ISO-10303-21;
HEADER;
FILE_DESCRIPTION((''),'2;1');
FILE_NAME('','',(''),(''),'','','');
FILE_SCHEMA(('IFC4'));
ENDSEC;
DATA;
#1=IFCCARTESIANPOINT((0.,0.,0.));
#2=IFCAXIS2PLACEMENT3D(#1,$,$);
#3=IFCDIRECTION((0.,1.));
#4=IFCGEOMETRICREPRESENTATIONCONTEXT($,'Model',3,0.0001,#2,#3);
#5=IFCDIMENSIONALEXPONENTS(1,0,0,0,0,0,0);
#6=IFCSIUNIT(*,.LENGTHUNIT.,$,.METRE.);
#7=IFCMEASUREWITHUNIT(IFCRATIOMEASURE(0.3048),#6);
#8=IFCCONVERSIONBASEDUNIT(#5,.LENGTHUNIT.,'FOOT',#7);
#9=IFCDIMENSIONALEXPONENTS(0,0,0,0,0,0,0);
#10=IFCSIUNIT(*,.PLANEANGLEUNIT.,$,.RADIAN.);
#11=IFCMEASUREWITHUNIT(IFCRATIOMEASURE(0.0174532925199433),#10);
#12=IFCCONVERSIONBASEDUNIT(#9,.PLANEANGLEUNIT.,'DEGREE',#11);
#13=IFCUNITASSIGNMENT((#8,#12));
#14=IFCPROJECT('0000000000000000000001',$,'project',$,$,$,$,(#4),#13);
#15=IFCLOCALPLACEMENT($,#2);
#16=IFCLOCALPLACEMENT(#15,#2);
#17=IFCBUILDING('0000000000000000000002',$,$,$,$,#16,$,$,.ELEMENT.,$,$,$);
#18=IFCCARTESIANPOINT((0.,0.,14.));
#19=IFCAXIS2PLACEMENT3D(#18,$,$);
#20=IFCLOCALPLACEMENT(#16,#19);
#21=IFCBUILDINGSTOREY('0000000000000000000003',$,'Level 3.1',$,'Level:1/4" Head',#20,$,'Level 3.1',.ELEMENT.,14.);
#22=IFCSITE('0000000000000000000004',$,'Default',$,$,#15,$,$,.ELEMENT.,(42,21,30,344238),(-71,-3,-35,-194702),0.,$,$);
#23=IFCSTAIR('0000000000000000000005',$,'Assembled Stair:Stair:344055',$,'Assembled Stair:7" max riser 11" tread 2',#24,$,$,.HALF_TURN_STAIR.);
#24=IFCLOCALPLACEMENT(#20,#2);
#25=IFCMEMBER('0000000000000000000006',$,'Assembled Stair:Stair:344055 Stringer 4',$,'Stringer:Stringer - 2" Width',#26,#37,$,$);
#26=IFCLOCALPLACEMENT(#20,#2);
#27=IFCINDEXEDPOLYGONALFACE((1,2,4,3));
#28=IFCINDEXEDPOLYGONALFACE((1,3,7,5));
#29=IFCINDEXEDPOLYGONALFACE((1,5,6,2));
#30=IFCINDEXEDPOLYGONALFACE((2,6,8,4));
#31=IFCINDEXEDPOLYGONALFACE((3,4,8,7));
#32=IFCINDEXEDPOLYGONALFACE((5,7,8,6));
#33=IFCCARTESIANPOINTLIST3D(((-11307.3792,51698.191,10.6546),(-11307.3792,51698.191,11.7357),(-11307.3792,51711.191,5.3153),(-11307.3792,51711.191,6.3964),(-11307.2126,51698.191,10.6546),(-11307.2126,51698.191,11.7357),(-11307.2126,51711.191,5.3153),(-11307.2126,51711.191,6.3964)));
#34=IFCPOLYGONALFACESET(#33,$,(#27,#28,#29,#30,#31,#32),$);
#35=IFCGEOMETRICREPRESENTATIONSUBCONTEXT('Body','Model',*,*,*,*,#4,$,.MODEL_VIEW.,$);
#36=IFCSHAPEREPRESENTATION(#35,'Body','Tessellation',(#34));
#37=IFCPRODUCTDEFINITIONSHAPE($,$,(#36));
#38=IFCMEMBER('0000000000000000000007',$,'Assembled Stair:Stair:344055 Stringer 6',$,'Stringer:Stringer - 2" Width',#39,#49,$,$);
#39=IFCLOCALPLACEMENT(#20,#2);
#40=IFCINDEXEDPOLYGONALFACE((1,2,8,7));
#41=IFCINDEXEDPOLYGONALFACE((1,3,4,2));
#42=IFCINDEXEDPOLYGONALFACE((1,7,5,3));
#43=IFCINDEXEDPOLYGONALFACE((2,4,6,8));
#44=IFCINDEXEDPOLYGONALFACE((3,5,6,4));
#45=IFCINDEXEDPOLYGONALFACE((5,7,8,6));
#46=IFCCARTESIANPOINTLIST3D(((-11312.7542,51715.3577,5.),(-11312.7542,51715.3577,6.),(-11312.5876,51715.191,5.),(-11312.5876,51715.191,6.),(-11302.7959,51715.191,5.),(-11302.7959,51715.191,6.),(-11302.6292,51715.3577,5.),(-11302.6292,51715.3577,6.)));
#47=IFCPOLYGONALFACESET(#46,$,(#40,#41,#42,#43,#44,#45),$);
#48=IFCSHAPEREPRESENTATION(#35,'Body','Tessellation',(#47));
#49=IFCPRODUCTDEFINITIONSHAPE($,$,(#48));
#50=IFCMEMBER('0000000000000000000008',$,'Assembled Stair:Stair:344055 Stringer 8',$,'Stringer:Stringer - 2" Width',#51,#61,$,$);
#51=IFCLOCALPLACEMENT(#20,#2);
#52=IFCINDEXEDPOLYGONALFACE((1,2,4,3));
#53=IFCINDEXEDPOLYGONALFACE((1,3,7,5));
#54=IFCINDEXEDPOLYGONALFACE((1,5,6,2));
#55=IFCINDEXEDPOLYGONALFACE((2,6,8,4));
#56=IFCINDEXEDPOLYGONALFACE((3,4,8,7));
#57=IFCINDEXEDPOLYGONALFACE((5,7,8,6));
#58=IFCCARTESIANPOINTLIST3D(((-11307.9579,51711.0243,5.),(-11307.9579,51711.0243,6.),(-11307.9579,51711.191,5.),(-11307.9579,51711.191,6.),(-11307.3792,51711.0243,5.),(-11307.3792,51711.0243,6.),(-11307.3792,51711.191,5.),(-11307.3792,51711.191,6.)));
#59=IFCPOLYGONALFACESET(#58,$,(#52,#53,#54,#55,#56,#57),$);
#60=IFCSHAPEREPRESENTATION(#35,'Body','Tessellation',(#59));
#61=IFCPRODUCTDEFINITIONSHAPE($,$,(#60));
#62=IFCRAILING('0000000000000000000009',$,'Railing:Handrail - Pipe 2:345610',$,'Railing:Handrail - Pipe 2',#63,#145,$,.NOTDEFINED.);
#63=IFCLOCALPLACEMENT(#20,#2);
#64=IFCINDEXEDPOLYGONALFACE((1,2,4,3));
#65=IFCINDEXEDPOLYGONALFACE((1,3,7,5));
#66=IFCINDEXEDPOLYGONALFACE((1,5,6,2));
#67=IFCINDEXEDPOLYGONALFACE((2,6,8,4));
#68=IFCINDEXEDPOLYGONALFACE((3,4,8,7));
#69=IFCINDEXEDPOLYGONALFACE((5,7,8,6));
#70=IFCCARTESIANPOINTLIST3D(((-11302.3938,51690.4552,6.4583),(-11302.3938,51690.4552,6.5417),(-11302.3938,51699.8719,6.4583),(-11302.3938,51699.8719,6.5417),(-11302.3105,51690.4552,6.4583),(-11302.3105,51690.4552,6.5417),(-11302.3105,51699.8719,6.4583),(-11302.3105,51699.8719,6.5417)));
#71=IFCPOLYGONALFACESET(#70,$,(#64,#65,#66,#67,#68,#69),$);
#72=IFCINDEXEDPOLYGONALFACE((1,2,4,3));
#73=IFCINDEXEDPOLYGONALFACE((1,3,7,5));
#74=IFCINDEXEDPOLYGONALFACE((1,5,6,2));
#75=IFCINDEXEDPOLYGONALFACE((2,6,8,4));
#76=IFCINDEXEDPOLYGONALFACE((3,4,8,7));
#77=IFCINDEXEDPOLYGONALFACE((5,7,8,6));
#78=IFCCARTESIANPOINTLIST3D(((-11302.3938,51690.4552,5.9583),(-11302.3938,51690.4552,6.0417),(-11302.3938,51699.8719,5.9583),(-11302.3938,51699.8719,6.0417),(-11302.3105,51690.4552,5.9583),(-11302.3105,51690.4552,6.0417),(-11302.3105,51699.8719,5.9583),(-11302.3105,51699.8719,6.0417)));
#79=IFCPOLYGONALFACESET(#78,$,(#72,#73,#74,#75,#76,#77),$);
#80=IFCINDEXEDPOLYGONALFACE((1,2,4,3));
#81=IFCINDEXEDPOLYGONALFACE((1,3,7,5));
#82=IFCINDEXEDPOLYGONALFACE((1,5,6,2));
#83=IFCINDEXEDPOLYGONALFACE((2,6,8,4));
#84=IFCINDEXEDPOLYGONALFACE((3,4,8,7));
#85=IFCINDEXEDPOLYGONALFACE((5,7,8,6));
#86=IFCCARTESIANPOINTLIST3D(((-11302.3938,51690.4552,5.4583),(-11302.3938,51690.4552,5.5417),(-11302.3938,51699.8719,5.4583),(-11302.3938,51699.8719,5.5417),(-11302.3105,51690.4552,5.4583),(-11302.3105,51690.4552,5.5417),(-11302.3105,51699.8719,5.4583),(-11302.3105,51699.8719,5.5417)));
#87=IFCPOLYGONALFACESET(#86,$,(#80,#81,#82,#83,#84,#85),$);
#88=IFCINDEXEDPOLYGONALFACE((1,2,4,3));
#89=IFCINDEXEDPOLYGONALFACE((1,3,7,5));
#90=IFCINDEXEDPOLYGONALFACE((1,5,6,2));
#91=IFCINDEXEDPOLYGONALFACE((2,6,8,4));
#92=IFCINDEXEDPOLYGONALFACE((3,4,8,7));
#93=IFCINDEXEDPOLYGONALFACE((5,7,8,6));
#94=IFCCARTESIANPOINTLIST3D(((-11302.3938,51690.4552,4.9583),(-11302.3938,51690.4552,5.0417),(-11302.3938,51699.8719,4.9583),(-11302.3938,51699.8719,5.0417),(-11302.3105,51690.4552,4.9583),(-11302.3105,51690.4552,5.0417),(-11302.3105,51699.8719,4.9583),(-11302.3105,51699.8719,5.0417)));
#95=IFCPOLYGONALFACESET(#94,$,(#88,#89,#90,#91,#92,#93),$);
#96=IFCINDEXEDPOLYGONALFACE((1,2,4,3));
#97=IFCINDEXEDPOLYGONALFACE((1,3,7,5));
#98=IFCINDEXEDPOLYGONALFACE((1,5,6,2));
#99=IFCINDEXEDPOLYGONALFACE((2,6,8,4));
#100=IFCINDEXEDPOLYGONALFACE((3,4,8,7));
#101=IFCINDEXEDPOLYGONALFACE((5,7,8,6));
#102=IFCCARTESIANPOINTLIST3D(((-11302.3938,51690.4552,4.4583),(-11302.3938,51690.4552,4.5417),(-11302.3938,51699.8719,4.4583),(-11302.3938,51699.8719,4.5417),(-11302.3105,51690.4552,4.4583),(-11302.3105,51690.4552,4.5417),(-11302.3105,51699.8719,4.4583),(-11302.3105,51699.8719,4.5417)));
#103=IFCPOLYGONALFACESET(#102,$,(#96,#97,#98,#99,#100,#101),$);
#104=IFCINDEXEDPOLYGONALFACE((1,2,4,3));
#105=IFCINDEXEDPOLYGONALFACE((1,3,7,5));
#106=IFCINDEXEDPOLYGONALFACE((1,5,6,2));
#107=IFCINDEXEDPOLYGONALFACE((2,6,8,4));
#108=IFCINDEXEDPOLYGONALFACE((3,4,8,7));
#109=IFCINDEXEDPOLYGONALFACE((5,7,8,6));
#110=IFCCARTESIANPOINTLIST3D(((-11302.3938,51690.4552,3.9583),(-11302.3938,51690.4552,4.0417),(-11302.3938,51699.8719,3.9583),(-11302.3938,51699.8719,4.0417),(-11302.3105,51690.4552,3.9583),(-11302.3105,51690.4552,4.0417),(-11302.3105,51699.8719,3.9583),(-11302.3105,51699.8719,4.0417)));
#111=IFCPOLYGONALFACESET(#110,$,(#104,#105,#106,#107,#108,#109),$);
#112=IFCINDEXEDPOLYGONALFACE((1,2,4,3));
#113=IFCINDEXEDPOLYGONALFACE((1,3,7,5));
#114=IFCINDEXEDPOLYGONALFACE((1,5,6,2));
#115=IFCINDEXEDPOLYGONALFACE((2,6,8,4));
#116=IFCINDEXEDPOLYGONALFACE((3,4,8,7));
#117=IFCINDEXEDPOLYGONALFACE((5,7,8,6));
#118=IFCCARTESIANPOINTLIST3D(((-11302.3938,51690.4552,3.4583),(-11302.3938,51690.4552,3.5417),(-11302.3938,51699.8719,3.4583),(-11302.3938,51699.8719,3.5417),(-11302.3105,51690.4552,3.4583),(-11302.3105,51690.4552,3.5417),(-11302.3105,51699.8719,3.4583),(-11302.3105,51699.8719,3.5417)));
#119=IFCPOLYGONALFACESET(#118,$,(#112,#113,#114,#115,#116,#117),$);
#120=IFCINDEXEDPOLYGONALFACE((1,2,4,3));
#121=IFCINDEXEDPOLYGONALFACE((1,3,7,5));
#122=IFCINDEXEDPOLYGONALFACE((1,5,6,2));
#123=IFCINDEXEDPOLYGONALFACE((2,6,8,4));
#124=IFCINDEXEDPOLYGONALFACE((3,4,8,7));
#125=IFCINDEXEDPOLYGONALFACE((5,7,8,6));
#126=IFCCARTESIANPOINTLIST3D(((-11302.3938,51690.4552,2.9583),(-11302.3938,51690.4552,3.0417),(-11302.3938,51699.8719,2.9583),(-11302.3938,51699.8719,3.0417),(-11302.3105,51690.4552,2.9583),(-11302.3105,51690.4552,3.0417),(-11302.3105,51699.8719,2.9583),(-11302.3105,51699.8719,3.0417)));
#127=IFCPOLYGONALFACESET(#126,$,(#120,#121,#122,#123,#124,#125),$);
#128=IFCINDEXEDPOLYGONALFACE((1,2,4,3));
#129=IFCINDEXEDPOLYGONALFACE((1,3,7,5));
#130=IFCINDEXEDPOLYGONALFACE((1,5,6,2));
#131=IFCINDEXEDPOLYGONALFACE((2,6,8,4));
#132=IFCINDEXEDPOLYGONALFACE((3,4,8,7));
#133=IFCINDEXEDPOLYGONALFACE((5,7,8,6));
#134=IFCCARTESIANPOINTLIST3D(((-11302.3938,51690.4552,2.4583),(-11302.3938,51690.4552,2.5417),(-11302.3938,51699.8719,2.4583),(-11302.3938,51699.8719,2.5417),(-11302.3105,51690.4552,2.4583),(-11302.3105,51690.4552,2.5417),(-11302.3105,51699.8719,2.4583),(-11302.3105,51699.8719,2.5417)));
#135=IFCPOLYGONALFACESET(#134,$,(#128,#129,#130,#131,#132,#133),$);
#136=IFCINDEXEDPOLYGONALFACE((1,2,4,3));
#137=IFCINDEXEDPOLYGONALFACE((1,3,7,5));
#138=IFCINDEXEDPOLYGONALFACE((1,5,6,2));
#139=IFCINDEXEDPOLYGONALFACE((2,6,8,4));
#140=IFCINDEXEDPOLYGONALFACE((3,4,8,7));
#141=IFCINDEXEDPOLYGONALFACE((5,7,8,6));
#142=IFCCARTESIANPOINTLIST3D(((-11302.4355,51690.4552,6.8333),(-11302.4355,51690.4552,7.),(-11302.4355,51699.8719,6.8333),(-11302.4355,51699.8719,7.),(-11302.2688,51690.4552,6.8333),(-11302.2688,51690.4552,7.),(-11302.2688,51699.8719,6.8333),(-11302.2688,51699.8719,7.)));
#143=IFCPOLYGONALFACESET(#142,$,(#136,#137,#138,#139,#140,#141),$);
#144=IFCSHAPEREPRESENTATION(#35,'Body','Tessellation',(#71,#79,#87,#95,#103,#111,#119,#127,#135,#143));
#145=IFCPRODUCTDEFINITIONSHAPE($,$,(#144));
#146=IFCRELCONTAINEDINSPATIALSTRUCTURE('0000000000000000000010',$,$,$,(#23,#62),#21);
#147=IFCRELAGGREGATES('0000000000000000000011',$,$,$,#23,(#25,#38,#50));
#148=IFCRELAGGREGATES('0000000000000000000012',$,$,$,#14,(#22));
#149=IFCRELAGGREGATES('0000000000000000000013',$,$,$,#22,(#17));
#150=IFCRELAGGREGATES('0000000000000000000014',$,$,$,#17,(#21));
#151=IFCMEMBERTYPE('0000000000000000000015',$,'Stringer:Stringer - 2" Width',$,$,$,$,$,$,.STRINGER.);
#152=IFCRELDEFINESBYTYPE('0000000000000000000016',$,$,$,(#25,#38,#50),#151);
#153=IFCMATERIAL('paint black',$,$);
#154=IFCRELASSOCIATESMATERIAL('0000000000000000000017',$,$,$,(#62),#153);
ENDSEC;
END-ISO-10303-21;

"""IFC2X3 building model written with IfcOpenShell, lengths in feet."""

from ifc_helpers import new_model, entity, si_unit, converted_unit, direction, frame, frame_2d, origin, place, context, subcontext, project, spatial, polyline, rectangle, outline, extrude, material, type_object, element, aggregate, save


model = new_model("IFC2X3")

# Units and contexts
model_context = context("Model", 3, precision=0.0001, world=origin(), true_north=direction((0.0, 1.0)))
body_context = subcontext(model_context, "Body", "Model", "MODEL_VIEW")
ifc_project = project(units=[converted_unit("LENGTHUNIT", "FOOT", entity("IfcRatioMeasure", 0.3048), si_unit("LENGTHUNIT", "METRE"), dimensions=[1, 0, 0, 0, 0, 0, 0]), converted_unit("PLANEANGLEUNIT", "DEGREE", entity("IfcRatioMeasure", 0.0174532925199433), si_unit("PLANEANGLEUNIT", "RADIAN"), dimensions=[0, 0, 0, 0, 0, 0, 0])], contexts=[model_context])

# Site, building, storey
site_placement = place(None, origin())
site = spatial("IfcSite", under=ifc_project, at=site_placement, Name="Default", CompositionType="ELEMENT", RefLatitude=(42, 21, 30, 344238), RefLongitude=(-71, -3, -35, -194702), RefElevation=0.0)
building_placement = place(site_placement, origin())
building = spatial("IfcBuilding", under=site, at=building_placement, CompositionType="ELEMENT")
storey_placement = place(building_placement, frame((0.0, 0.0, 14.0)))
storey = spatial("IfcBuildingStorey", under=building, at=storey_placement, Name="Level 3.1", ObjectType="Level:1/4\" Head", LongName="Level 3.1", CompositionType="ELEMENT", Elevation=14.0)

# Stair, members
stair_placement = place(storey_placement, origin())
stair = element("IfcStair", 1, at=stair_placement, inside=storey, Name="Assembled Stair:Stair:344055", ObjectType="Assembled Stair:7\" max riser 11\" tread 2", ShapeType="HALF_TURN_STAIR")
member_type = type_object("IfcMemberType", Name="Stringer:Stringer - 2\" Width", PredefinedType="STRINGER")
member_1_placement = place(stair_placement, origin())
member_1 = element("IfcMember", 2, at=member_1_placement, type_object=member_type, Name="Assembled Stair:Stair:344055 Stringer 4", ObjectType="Stringer:Stringer - 2\" Width", context=body_context, shape_type="SweptSolid", body=[
    extrude(outline(polyline([(-6.8215, -0.5), (7.2322, -0.5), (6.8215, 0.5), (-7.2322, 0.5), (-6.8215, -0.5)])), frame((-11307.3792, 51704.691, 8.5255), z_axis=(1.0, 0.0, 0.0), x_axis=(0.0, -0.92502, 0.379919)), (0.0, 0.0, 1.0), 0.1667),
])
member_2_placement = place(stair_placement, origin())
member_2 = element("IfcMember", 3, at=member_2_placement, type_object=member_type, Name="Assembled Stair:Stair:344055 Stringer 6", ObjectType="Stringer:Stringer - 2\" Width", context=body_context, shape_type="SweptSolid", body=[
    extrude(outline(polyline([(-5.0625, -0.0833), (5.0625, -0.0833), (4.8958, 0.0833), (-4.8958, 0.0833), (-5.0625, -0.0833)])), frame((-11307.6917, 51715.2743, 5.0), z_axis=(0.0, 0.0, 1.0), x_axis=(-1.0, 0.0, 0.0)), (0.0, 0.0, 1.0), 1.0),
])
member_3_placement = place(stair_placement, origin())
member_3 = element("IfcMember", 4, at=member_3_placement, type_object=member_type, Name="Assembled Stair:Stair:344055 Stringer 8", ObjectType="Stringer:Stringer - 2\" Width", context=body_context, shape_type="SweptSolid", body=[
    extrude(rectangle(XDim=0.5786, YDim=0.1667, at=frame_2d((0.0, 0.0), x_axis=(1.0, 0.0))), frame((-11307.6686, 51711.1077, 5.0)), (0.0, 0.0, 1.0), 1.0),
])
aggregate(stair, [member_1, member_2, member_3])

# Railing
ifc_material_1 = material(Name="paint black")
railing_1_placement = place(storey_placement, origin())
element("IfcRailing", 5, at=railing_1_placement, inside=storey, material=ifc_material_1, Name="Railing:Handrail - Pipe 2:345610", ObjectType="Railing:Handrail - Pipe 2", PredefinedType="NOTDEFINED", context=body_context, shape_type="SweptSolid", body=[
    extrude(rectangle(XDim=9.4167, YDim=0.0833, at=frame_2d((0.0, 0.0), x_axis=(1.0, 0.0))), frame((-11302.3522, 51695.1636, 6.4583), z_axis=(0.0, 0.0, 1.0), x_axis=(0.0, 1.0, 0.0)), (0.0, 0.0, 1.0), 0.0833),
    extrude(rectangle(XDim=9.4167, YDim=0.0833, at=frame_2d((0.0, 0.0), x_axis=(1.0, 0.0))), frame((-11302.3522, 51695.1636, 5.9583), z_axis=(0.0, 0.0, 1.0), x_axis=(0.0, 1.0, 0.0)), (0.0, 0.0, 1.0), 0.0833),
    extrude(rectangle(XDim=9.4167, YDim=0.0833, at=frame_2d((0.0, 0.0), x_axis=(1.0, 0.0))), frame((-11302.3522, 51695.1636, 5.4583), z_axis=(0.0, 0.0, 1.0), x_axis=(0.0, 1.0, 0.0)), (0.0, 0.0, 1.0), 0.0833),
    extrude(rectangle(XDim=9.4167, YDim=0.0833, at=frame_2d((0.0, 0.0), x_axis=(1.0, 0.0))), frame((-11302.3522, 51695.1636, 4.9583), z_axis=(0.0, 0.0, 1.0), x_axis=(0.0, 1.0, 0.0)), (0.0, 0.0, 1.0), 0.0833),
    extrude(rectangle(XDim=9.4167, YDim=0.0833, at=frame_2d((0.0, 0.0), x_axis=(1.0, 0.0))), frame((-11302.3522, 51695.1636, 4.4583), z_axis=(0.0, 0.0, 1.0), x_axis=(0.0, 1.0, 0.0)), (0.0, 0.0, 1.0), 0.0833),
    extrude(rectangle(XDim=9.4167, YDim=0.0833, at=frame_2d((0.0, 0.0), x_axis=(1.0, 0.0))), frame((-11302.3522, 51695.1636, 3.9583), z_axis=(0.0, 0.0, 1.0), x_axis=(0.0, 1.0, 0.0)), (0.0, 0.0, 1.0), 0.0833),
    extrude(rectangle(XDim=9.4167, YDim=0.0833, at=frame_2d((0.0, 0.0), x_axis=(1.0, 0.0))), frame((-11302.3522, 51695.1636, 3.4583), z_axis=(0.0, 0.0, 1.0), x_axis=(0.0, 1.0, 0.0)), (0.0, 0.0, 1.0), 0.0833),
    extrude(rectangle(XDim=9.4167, YDim=0.0833, at=frame_2d((0.0, 0.0), x_axis=(1.0, 0.0))), frame((-11302.3522, 51695.1636, 2.9583), z_axis=(0.0, 0.0, 1.0), x_axis=(0.0, 1.0, 0.0)), (0.0, 0.0, 1.0), 0.0833),
    extrude(rectangle(XDim=9.4167, YDim=0.0833, at=frame_2d((0.0, 0.0), x_axis=(1.0, 0.0))), frame((-11302.3522, 51695.1636, 2.4583), z_axis=(0.0, 0.0, 1.0), x_axis=(0.0, 1.0, 0.0)), (0.0, 0.0, 1.0), 0.0833),
    extrude(rectangle(XDim=9.4167, YDim=0.1667, at=frame_2d((0.0, 0.0), x_axis=(1.0, 0.0))), frame((-11302.3522, 51695.1636, 6.8333), z_axis=(0.0, 0.0, 1.0), x_axis=(0.0, 1.0, 0.0)), (0.0, 0.0, 1.0), 0.1667),
])

save(model, "model.ifc")
